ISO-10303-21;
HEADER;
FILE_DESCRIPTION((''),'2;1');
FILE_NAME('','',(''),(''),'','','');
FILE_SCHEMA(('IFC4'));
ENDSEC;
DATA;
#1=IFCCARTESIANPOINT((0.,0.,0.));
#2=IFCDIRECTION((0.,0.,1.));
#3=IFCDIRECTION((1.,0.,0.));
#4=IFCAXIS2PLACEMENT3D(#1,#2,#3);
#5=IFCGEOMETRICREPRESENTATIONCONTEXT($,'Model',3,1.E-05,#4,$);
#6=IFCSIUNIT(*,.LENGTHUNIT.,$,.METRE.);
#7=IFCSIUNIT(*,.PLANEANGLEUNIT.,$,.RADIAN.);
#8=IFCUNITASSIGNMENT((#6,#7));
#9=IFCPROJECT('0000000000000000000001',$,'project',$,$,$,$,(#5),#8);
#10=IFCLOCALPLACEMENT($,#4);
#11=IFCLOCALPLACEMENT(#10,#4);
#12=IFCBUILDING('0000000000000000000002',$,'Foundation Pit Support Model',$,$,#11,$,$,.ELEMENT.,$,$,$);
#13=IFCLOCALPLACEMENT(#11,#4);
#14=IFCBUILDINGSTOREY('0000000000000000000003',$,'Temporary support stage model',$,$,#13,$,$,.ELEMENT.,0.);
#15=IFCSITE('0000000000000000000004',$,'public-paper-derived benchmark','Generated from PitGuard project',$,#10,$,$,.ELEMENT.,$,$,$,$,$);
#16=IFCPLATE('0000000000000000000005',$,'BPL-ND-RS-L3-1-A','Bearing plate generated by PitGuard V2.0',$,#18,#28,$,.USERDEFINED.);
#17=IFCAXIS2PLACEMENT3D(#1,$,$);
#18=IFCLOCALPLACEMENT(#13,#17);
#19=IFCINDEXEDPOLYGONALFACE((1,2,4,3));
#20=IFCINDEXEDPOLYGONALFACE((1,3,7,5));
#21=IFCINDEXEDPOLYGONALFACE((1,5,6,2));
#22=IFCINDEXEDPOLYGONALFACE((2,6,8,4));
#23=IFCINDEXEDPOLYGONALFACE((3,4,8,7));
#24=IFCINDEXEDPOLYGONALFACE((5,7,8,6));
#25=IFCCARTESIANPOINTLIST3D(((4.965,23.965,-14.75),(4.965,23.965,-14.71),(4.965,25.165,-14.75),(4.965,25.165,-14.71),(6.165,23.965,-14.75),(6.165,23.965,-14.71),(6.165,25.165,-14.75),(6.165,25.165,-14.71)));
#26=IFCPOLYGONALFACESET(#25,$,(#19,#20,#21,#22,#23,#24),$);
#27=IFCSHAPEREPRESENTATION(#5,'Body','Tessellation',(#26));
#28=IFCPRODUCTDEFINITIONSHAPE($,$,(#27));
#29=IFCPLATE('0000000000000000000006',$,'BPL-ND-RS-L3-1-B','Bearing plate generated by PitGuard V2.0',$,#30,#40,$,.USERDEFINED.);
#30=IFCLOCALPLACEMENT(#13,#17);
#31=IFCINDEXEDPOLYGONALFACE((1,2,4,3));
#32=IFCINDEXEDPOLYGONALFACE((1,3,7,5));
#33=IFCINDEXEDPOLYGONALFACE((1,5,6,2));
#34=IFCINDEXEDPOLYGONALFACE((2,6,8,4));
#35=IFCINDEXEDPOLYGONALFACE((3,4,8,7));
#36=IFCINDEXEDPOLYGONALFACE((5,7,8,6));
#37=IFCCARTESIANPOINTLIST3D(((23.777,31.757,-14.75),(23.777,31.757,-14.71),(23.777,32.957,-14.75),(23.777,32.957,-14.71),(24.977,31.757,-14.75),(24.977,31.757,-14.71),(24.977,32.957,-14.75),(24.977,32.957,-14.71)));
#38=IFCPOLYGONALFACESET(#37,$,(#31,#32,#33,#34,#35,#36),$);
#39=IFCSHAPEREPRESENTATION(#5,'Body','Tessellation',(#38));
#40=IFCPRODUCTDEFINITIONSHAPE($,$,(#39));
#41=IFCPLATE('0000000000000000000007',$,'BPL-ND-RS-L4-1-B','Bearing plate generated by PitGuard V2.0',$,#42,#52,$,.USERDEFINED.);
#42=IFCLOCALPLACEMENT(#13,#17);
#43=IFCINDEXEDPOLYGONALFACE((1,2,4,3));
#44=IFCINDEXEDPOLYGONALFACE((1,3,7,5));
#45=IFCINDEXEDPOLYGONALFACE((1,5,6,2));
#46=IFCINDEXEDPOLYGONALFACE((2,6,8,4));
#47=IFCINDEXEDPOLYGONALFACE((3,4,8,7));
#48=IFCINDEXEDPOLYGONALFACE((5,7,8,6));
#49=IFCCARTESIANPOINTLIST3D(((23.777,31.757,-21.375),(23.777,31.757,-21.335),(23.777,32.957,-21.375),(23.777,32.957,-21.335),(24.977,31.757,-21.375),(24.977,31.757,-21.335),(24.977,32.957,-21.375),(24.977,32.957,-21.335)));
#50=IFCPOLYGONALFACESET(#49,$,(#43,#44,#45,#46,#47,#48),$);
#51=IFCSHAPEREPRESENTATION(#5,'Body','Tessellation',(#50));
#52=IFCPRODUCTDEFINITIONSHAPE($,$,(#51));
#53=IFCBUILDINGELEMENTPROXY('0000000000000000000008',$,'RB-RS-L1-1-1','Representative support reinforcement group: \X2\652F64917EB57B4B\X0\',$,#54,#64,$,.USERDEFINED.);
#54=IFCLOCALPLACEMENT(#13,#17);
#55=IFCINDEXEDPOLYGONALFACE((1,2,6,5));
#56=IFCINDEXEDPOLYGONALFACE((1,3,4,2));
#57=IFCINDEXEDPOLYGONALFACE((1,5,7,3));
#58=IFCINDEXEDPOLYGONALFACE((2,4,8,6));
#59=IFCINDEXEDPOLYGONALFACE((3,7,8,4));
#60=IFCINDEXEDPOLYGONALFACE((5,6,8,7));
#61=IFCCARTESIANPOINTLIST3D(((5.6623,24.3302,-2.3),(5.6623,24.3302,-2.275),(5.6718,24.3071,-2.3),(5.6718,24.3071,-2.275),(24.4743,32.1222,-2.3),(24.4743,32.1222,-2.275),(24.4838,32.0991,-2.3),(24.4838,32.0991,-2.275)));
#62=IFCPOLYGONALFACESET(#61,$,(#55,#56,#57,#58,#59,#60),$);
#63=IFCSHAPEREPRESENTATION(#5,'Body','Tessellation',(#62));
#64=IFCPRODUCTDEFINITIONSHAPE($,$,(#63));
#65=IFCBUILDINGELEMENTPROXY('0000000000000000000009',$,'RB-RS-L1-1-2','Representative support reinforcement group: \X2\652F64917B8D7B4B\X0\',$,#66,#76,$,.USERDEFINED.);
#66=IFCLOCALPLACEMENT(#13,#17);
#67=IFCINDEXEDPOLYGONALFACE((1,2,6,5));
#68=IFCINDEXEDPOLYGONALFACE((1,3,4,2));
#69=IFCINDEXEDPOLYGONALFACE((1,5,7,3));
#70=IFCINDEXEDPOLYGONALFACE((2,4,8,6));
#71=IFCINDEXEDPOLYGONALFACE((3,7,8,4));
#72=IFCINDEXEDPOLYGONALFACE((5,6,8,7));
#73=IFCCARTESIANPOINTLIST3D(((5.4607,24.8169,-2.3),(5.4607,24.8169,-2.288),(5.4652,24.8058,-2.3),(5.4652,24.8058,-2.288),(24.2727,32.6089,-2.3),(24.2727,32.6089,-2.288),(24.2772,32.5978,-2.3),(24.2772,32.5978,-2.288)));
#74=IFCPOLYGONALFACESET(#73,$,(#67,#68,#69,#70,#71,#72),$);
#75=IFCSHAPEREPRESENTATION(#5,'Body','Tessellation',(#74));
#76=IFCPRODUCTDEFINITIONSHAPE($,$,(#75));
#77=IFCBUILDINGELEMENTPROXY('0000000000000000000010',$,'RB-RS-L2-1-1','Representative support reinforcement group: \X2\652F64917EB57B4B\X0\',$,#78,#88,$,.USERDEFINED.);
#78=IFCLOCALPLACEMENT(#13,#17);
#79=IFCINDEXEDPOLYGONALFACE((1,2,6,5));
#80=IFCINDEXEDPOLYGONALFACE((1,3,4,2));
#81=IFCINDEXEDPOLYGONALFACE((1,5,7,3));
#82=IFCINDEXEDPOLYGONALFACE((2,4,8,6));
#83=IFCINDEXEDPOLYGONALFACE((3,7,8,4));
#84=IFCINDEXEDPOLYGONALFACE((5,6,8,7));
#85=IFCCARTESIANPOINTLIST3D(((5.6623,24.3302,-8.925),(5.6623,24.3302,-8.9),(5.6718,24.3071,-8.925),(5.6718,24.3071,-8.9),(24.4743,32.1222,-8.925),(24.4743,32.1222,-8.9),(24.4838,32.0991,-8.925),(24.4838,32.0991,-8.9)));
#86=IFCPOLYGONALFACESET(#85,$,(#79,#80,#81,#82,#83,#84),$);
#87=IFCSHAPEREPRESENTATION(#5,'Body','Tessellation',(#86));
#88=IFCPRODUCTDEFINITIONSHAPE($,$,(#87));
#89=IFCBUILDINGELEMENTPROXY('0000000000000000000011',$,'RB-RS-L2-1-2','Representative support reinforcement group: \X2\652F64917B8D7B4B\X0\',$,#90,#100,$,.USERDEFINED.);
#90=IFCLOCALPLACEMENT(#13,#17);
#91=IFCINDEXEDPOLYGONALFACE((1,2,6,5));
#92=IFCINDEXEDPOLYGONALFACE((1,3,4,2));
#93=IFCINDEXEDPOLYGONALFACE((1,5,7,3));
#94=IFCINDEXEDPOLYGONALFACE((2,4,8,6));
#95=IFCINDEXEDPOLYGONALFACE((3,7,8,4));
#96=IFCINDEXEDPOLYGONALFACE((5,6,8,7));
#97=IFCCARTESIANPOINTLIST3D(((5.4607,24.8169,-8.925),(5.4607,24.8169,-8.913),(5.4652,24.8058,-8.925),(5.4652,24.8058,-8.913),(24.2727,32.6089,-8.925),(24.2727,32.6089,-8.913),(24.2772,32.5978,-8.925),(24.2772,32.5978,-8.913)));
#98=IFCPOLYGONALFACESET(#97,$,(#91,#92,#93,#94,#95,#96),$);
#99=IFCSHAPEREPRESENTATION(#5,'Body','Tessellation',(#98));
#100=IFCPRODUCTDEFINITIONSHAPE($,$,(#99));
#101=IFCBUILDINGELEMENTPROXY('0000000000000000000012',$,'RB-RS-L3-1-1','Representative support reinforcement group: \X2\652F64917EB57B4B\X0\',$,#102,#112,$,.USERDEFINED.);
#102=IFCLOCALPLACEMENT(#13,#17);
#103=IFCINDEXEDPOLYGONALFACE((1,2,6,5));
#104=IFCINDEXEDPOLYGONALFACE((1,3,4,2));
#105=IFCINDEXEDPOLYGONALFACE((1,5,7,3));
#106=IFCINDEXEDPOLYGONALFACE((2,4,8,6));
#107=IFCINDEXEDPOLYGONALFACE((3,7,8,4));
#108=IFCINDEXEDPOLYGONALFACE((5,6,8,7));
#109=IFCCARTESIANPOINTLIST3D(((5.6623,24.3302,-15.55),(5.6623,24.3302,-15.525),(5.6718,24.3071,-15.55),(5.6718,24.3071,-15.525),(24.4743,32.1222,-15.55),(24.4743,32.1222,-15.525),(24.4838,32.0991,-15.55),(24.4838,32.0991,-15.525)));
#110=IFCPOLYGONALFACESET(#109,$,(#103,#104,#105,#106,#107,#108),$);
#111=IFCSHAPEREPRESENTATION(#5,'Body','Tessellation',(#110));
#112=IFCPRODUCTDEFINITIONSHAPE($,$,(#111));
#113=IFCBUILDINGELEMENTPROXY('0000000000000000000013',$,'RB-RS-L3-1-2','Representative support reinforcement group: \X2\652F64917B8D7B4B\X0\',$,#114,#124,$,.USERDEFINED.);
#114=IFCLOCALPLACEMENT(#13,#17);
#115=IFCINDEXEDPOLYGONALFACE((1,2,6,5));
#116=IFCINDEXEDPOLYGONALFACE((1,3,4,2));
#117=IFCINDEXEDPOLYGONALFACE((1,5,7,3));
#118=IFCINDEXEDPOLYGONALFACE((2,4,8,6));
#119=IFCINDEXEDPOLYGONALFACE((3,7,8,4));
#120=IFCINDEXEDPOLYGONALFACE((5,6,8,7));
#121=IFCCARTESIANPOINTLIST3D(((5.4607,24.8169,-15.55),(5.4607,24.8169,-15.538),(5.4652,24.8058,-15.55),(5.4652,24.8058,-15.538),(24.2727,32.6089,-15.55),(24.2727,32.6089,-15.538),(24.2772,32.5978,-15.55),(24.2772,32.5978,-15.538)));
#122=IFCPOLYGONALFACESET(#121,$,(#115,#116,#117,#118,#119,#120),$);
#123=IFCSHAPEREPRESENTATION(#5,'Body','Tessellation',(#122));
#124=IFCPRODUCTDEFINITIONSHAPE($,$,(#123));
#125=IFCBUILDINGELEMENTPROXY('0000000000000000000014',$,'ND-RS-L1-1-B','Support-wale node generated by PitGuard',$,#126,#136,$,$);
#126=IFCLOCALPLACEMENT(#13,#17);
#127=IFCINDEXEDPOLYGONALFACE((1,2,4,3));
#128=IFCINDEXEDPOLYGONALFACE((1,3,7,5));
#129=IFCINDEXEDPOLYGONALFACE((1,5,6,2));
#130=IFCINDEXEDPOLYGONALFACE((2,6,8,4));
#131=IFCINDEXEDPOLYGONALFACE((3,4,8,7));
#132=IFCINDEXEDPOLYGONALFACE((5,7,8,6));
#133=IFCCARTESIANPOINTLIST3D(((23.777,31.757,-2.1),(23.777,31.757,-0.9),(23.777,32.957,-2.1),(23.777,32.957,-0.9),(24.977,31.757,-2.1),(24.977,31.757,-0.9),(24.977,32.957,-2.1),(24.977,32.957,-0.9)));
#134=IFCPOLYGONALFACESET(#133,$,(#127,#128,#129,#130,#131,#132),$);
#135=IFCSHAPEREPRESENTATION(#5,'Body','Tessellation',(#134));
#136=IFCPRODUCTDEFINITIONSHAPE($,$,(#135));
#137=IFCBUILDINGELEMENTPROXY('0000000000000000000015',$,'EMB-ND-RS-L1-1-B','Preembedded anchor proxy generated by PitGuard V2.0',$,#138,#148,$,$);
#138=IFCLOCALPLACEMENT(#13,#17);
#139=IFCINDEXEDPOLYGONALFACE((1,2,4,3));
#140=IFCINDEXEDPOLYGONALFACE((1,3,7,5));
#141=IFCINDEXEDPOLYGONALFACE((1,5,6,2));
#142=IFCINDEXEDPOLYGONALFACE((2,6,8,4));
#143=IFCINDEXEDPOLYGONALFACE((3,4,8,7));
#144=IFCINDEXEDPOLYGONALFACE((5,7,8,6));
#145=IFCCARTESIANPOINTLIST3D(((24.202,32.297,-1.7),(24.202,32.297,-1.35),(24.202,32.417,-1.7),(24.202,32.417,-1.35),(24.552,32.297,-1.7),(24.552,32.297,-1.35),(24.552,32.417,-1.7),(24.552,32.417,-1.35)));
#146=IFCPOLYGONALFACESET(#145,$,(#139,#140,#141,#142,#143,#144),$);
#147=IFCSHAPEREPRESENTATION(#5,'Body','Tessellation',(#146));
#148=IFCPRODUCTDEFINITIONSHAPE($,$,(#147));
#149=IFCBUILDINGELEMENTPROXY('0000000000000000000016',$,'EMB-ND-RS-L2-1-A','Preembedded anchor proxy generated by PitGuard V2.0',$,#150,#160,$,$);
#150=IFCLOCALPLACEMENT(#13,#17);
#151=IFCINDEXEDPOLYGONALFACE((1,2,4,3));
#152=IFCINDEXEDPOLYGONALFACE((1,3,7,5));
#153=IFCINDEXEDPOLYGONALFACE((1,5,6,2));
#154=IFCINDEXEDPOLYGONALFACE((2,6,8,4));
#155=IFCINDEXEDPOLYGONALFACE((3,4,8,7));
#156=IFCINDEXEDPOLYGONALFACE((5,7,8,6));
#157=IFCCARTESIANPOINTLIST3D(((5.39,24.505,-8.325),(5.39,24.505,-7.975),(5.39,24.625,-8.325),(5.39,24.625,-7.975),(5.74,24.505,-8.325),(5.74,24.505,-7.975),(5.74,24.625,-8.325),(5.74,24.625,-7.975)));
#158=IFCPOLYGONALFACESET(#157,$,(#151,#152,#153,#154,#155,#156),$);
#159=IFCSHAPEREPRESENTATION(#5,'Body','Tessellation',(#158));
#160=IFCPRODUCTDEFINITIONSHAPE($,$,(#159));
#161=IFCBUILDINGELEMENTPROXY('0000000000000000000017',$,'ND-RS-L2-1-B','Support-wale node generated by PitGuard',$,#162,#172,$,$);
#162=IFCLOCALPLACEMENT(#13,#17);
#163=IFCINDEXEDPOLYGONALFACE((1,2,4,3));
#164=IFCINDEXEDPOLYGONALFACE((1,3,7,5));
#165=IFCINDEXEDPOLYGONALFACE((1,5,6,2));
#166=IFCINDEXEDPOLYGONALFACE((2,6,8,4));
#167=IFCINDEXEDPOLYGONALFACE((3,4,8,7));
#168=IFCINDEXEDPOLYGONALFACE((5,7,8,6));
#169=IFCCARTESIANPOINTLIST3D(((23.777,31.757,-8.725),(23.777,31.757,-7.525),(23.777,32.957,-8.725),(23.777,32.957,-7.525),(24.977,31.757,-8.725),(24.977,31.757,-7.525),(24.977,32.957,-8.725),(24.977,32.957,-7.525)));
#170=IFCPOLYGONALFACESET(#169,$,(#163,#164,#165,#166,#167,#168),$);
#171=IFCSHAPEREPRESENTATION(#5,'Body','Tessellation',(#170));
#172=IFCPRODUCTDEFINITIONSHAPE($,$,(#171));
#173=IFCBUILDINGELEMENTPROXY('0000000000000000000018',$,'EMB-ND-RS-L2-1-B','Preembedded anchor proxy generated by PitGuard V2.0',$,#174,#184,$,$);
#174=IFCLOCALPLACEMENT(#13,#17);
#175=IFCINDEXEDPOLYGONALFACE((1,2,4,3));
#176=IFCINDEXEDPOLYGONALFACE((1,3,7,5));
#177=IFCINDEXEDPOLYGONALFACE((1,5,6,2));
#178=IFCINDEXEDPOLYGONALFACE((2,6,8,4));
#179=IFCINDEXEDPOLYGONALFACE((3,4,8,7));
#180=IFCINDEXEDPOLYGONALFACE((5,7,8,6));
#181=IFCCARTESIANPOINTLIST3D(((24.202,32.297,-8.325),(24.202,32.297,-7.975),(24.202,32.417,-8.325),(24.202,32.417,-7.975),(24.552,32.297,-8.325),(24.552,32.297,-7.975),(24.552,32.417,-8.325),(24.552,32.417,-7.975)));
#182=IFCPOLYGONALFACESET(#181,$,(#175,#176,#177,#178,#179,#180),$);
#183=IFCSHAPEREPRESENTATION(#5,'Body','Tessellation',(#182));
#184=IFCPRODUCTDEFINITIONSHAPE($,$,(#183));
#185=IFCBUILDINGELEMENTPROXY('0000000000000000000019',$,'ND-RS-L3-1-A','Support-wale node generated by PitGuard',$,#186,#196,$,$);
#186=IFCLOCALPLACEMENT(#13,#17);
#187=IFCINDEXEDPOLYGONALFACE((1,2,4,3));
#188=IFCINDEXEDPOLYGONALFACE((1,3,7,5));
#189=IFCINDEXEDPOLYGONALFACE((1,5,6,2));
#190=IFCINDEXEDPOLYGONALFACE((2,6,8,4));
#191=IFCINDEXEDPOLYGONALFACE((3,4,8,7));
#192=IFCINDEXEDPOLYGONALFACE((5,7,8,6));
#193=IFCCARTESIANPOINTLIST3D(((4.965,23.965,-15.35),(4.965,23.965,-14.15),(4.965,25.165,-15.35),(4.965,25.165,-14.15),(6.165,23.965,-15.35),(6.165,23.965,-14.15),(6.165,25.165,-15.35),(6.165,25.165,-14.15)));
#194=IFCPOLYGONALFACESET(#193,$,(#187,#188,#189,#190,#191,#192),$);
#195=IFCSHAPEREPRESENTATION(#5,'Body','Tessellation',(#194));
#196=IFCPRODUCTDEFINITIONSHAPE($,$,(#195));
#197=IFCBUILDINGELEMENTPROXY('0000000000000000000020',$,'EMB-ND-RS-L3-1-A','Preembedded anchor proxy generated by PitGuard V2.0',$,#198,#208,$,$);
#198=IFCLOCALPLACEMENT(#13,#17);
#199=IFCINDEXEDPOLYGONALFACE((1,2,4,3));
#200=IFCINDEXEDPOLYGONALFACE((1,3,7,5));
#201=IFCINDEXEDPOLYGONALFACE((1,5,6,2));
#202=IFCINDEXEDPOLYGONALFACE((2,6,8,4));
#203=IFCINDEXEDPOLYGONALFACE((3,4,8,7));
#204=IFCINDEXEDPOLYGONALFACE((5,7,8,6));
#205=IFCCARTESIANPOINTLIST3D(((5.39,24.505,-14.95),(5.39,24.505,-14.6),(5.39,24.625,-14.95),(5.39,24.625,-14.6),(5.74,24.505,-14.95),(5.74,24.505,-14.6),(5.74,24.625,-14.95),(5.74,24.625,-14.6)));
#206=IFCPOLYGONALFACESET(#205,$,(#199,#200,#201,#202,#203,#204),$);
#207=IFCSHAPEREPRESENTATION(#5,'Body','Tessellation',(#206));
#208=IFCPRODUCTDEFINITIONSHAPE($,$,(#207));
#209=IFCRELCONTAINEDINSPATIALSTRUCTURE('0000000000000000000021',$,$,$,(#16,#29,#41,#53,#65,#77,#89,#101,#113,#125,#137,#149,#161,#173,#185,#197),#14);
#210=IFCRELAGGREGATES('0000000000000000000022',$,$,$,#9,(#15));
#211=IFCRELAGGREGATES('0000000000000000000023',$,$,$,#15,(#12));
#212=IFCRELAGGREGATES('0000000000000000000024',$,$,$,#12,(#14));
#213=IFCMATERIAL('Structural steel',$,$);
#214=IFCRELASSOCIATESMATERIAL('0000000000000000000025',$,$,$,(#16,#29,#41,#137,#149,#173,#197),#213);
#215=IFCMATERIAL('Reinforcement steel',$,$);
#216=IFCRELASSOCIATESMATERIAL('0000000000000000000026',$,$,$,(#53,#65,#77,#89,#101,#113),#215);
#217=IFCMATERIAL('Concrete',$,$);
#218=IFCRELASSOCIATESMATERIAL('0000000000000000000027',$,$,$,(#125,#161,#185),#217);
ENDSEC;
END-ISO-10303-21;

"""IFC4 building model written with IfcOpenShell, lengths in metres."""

from ifc_helpers import new_model, si_unit, frame, origin_with_axes, origin_2d, place, context, project, spatial, rectangle, extrude, material, element, save


model = new_model("IFC4")

# Units and contexts
model_context = context("Model", 3, precision=1e-05, world=origin_with_axes())
ifc_project = project(units=[si_unit("LENGTHUNIT", "METRE"), si_unit("PLANEANGLEUNIT", "RADIAN")], contexts=[model_context])

# Site, building, storey
site_placement = place(None, origin_with_axes())
site = spatial("IfcSite", under=ifc_project, at=site_placement, Name="public-paper-derived benchmark", Description="Generated from PitGuard project", CompositionType="ELEMENT")
building_placement = place(site_placement, origin_with_axes())
building = spatial("IfcBuilding", under=site, at=building_placement, Name="Foundation Pit Support Model", CompositionType="ELEMENT")
storey_placement = place(building_placement, origin_with_axes())
storey = spatial("IfcBuildingStorey", under=building, at=storey_placement, Name="Temporary support stage model", CompositionType="ELEMENT", Elevation=0.0)

# Shared definitions
ifc_material_1 = material(Name="Concrete")

# Plates
ifc_material_2 = material(Name="Structural steel")
for number, where, z_axis, x_axis, name in (
    (1, (5.565, 24.565, -14.75), (0.0, 0.0, 1.0), (1.0, 0.0, 0.0), "BPL-ND-RS-L3-1-A"),
    (2, (24.377, 32.357, -14.75), (0.0, 0.0, 1.0), (1.0, 0.0, 0.0), "BPL-ND-RS-L3-1-B"),
    (3, (24.377, 32.357, -21.375), (0.0, 0.0, 1.0), (1.0, 0.0, 0.0), "BPL-ND-RS-L4-1-B"),
):
    element("IfcPlate", number, at=place(storey_placement, frame(where, z_axis=z_axis, x_axis=x_axis)), inside=storey, material=ifc_material_2, Name=name, Description="Bearing plate generated by PitGuard V2.0", PredefinedType="USERDEFINED", context=model_context, shape_type="SweptSolid", body=[
        extrude(rectangle(XDim=1.2, YDim=1.2, at=origin_2d()), origin_with_axes(), (0.0, 0.0, 1.0), 0.04),
    ])

# Building element proxies
ifc_material_3 = material(Name="Reinforcement steel")
proxy_1_placement = place(storey_placement, frame((15.073, 28.2146, -2.3), z_axis=(0.0, 0.0, 1.0), x_axis=(0.923883, 0.382676, 0.0)))
element("IfcBuildingElementProxy", 4, at=proxy_1_placement, inside=storey, material=ifc_material_3, Name="RB-RS-L1-1-1", Description="Representative support reinforcement group: 支撑纵筋", PredefinedType="USERDEFINED", context=model_context, shape_type="SweptSolid", body=[
    extrude(rectangle(XDim=20.3619, YDim=0.025, at=origin_2d()), origin_with_axes(), (0.0, 0.0, 1.0), 0.025),
])
proxy_2_placement = place(storey_placement, frame((14.869, 28.7074, -2.3), z_axis=(0.0, 0.0, 1.0), x_axis=(0.923883, 0.382676, 0.0)))
element("IfcBuildingElementProxy", 5, at=proxy_2_placement, inside=storey, material=ifc_material_3, Name="RB-RS-L1-1-2", Description="Representative support reinforcement group: 支撑箍筋", PredefinedType="USERDEFINED", context=model_context, shape_type="SweptSolid", body=[
    extrude(rectangle(XDim=20.3619, YDim=0.012, at=origin_2d()), origin_with_axes(), (0.0, 0.0, 1.0), 0.012),
])
proxy_3_placement = place(storey_placement, frame((15.073, 28.2146, -8.925), z_axis=(0.0, 0.0, 1.0), x_axis=(0.923883, 0.382676, 0.0)))
element("IfcBuildingElementProxy", 6, at=proxy_3_placement, inside=storey, material=ifc_material_3, Name="RB-RS-L2-1-1", Description="Representative support reinforcement group: 支撑纵筋", PredefinedType="USERDEFINED", context=model_context, shape_type="SweptSolid", body=[
    extrude(rectangle(XDim=20.3619, YDim=0.025, at=origin_2d()), origin_with_axes(), (0.0, 0.0, 1.0), 0.025),
])
proxy_4_placement = place(storey_placement, frame((14.869, 28.7074, -8.925), z_axis=(0.0, 0.0, 1.0), x_axis=(0.923883, 0.382676, 0.0)))
element("IfcBuildingElementProxy", 7, at=proxy_4_placement, inside=storey, material=ifc_material_3, Name="RB-RS-L2-1-2", Description="Representative support reinforcement group: 支撑箍筋", PredefinedType="USERDEFINED", context=model_context, shape_type="SweptSolid", body=[
    extrude(rectangle(XDim=20.3619, YDim=0.012, at=origin_2d()), origin_with_axes(), (0.0, 0.0, 1.0), 0.012),
])
proxy_5_placement = place(storey_placement, frame((15.073, 28.2146, -15.55), z_axis=(0.0, 0.0, 1.0), x_axis=(0.923883, 0.382676, 0.0)))
element("IfcBuildingElementProxy", 8, at=proxy_5_placement, inside=storey, material=ifc_material_3, Name="RB-RS-L3-1-1", Description="Representative support reinforcement group: 支撑纵筋", PredefinedType="USERDEFINED", context=model_context, shape_type="SweptSolid", body=[
    extrude(rectangle(XDim=20.3619, YDim=0.025, at=origin_2d()), origin_with_axes(), (0.0, 0.0, 1.0), 0.025),
])
proxy_6_placement = place(storey_placement, frame((14.869, 28.7074, -15.55), z_axis=(0.0, 0.0, 1.0), x_axis=(0.923883, 0.382676, 0.0)))
element("IfcBuildingElementProxy", 9, at=proxy_6_placement, inside=storey, material=ifc_material_3, Name="RB-RS-L3-1-2", Description="Representative support reinforcement group: 支撑箍筋", PredefinedType="USERDEFINED", context=model_context, shape_type="SweptSolid", body=[
    extrude(rectangle(XDim=20.3619, YDim=0.012, at=origin_2d()), origin_with_axes(), (0.0, 0.0, 1.0), 0.012),
])
proxy_7_placement = place(storey_placement, frame((24.377, 32.357, -2.1), z_axis=(0.0, 0.0, 1.0), x_axis=(1.0, 0.0, 0.0)))
element("IfcBuildingElementProxy", 10, at=proxy_7_placement, inside=storey, material=ifc_material_1, Name="ND-RS-L1-1-B", Description="Support-wale node generated by PitGuard", context=model_context, shape_type="SweptSolid", body=[
    extrude(rectangle(XDim=1.2, YDim=1.2, at=origin_2d()), origin_with_axes(), (0.0, 0.0, 1.0), 1.2),
])
for number, where, z_axis, x_axis, name in (
    (11, (24.377, 32.357, -1.7), (0.0, 0.0, 1.0), (1.0, 0.0, 0.0), "EMB-ND-RS-L1-1-B"),
    (12, (5.565, 24.565, -8.325), (0.0, 0.0, 1.0), (1.0, 0.0, 0.0), "EMB-ND-RS-L2-1-A"),
):
    element("IfcBuildingElementProxy", number, at=place(storey_placement, frame(where, z_axis=z_axis, x_axis=x_axis)), inside=storey, material=ifc_material_2, Name=name, Description="Preembedded anchor proxy generated by PitGuard V2.0", context=model_context, shape_type="SweptSolid", body=[
        extrude(rectangle(XDim=0.35, YDim=0.12, at=origin_2d()), origin_with_axes(), (0.0, 0.0, 1.0), 0.35),
    ])
proxy_8_placement = place(storey_placement, frame((24.377, 32.357, -8.725), z_axis=(0.0, 0.0, 1.0), x_axis=(1.0, 0.0, 0.0)))
element("IfcBuildingElementProxy", 13, at=proxy_8_placement, inside=storey, material=ifc_material_1, Name="ND-RS-L2-1-B", Description="Support-wale node generated by PitGuard", context=model_context, shape_type="SweptSolid", body=[
    extrude(rectangle(XDim=1.2, YDim=1.2, at=origin_2d()), origin_with_axes(), (0.0, 0.0, 1.0), 1.2),
])
proxy_9_placement = place(storey_placement, frame((24.377, 32.357, -8.325), z_axis=(0.0, 0.0, 1.0), x_axis=(1.0, 0.0, 0.0)))
element("IfcBuildingElementProxy", 14, at=proxy_9_placement, inside=storey, material=ifc_material_2, Name="EMB-ND-RS-L2-1-B", Description="Preembedded anchor proxy generated by PitGuard V2.0", context=model_context, shape_type="SweptSolid", body=[
    extrude(rectangle(XDim=0.35, YDim=0.12, at=origin_2d()), origin_with_axes(), (0.0, 0.0, 1.0), 0.35),
])
proxy_10_placement = place(storey_placement, frame((5.565, 24.565, -15.35), z_axis=(0.0, 0.0, 1.0), x_axis=(1.0, 0.0, 0.0)))
element("IfcBuildingElementProxy", 15, at=proxy_10_placement, inside=storey, material=ifc_material_1, Name="ND-RS-L3-1-A", Description="Support-wale node generated by PitGuard", context=model_context, shape_type="SweptSolid", body=[
    extrude(rectangle(XDim=1.2, YDim=1.2, at=origin_2d()), origin_with_axes(), (0.0, 0.0, 1.0), 1.2),
])
proxy_11_placement = place(storey_placement, frame((5.565, 24.565, -14.95), z_axis=(0.0, 0.0, 1.0), x_axis=(1.0, 0.0, 0.0)))
element("IfcBuildingElementProxy", 16, at=proxy_11_placement, inside=storey, material=ifc_material_2, Name="EMB-ND-RS-L3-1-A", Description="Preembedded anchor proxy generated by PitGuard V2.0", context=model_context, shape_type="SweptSolid", body=[
    extrude(rectangle(XDim=0.35, YDim=0.12, at=origin_2d()), origin_with_axes(), (0.0, 0.0, 1.0), 0.35),
])

save(model, "model.ifc")
